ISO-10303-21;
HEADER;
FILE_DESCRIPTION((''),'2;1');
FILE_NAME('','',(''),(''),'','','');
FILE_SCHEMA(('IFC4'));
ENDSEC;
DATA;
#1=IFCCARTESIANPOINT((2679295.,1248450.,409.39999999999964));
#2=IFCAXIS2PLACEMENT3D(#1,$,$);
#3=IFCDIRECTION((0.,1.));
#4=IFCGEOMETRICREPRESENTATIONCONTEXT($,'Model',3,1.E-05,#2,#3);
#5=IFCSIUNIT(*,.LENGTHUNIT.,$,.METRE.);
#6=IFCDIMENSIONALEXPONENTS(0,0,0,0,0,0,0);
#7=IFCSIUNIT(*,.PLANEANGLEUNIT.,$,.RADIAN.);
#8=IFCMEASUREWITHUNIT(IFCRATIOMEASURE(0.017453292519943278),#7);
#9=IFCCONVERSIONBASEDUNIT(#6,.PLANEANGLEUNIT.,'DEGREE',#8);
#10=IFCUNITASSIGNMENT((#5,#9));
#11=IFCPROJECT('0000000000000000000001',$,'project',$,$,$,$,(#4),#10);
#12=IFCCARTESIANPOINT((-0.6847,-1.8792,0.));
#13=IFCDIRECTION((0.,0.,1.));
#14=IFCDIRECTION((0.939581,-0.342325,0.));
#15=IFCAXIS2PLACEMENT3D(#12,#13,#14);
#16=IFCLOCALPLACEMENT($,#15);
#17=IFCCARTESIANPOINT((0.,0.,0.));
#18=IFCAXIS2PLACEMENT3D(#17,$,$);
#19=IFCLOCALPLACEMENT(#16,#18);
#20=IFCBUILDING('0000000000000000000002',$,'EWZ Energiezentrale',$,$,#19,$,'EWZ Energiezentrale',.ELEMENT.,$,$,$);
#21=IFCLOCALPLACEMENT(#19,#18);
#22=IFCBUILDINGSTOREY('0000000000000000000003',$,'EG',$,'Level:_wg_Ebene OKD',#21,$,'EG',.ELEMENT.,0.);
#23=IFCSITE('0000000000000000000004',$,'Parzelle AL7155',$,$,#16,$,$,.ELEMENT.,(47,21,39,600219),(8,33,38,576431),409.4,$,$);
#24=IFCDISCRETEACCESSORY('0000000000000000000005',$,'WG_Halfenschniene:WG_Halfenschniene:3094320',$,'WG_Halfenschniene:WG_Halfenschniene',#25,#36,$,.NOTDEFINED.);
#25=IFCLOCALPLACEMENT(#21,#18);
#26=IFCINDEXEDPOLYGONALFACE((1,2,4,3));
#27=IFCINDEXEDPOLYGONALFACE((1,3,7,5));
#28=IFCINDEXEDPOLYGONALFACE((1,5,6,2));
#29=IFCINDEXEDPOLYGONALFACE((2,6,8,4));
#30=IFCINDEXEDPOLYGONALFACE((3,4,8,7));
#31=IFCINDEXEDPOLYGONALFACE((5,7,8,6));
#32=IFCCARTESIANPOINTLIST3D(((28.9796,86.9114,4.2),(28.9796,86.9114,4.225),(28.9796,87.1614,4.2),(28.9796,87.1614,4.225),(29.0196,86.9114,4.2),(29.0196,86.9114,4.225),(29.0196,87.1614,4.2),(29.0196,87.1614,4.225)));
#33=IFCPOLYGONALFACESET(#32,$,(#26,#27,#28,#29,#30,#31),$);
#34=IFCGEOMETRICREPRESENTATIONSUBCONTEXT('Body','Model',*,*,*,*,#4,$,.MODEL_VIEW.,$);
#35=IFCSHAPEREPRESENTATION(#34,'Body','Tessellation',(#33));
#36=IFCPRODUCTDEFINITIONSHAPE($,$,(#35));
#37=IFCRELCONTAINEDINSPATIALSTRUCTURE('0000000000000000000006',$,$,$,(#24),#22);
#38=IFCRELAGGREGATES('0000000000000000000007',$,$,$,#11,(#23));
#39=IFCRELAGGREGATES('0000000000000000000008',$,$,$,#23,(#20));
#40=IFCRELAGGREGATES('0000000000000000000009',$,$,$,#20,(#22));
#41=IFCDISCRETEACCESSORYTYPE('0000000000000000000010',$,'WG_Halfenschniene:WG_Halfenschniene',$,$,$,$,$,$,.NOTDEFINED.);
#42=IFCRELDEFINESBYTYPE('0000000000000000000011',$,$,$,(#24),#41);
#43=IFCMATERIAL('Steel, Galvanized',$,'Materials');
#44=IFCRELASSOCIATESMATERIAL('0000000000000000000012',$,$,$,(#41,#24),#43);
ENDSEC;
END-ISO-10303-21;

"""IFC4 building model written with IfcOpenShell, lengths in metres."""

from ifc_helpers import new_model, entity, si_unit, converted_unit, direction, frame, origin, place, context, subcontext, project, spatial, indexed_curve, outline, extrude, source, transform, mapped, material, type_object, element, save


model = new_model("IFC4")

# Units and contexts
model_context = context("Model", 3, precision=1e-05, world=frame((2679295.0, 1248450.0, 409.39999999999964)), true_north=direction((0.0, 1.0)))
body_context = subcontext(model_context, "Body", "Model", "MODEL_VIEW")
ifc_project = project(units=[si_unit("LENGTHUNIT", "METRE"), converted_unit("PLANEANGLEUNIT", "DEGREE", entity("IfcRatioMeasure", 0.017453292519943278), si_unit("PLANEANGLEUNIT", "RADIAN"), dimensions=[0, 0, 0, 0, 0, 0, 0])], contexts=[model_context])

# Site, building, storey
site_placement = place(None, frame((-0.6847, -1.8792, 0.0), z_axis=(0.0, 0.0, 1.0), x_axis=(0.939581, -0.342325, 0.0)))
site = spatial("IfcSite", under=ifc_project, at=site_placement, Name="Parzelle AL7155", CompositionType="ELEMENT", RefLatitude=(47, 21, 39, 600219), RefLongitude=(8, 33, 38, 576431), RefElevation=409.4)
building_placement = place(site_placement, origin())
building = spatial("IfcBuilding", under=site, at=building_placement, Name="EWZ Energiezentrale", LongName="EWZ Energiezentrale", CompositionType="ELEMENT")
storey_placement = place(building_placement, origin())
storey = spatial("IfcBuildingStorey", under=building, at=storey_placement, Name="EG", ObjectType="Level:_wg_Ebene OKD", LongName="EG", CompositionType="ELEMENT", Elevation=0.0)

# Discrete accessory
ifc_material = material(Name="Steel, Galvanized", Category="Materials")
discrete_accessory_type = type_object("IfcDiscreteAccessoryType", Name="WG_Halfenschniene:WG_Halfenschniene", PredefinedType="NOTDEFINED", material=ifc_material)
shared_shape = source(origin(), body_context, "Body", "SweptSolid", [
    extrude(outline(indexed_curve([(-0.125, -0.02), (0.125, -0.02), (0.125, 0.02), (-0.125, 0.02), (-0.125, -0.02)], self_intersect=False)), frame((0.125, 0.0, -0.0125)), (0.0, 0.0, 1.0), 0.025),
])
for number, where, z_axis, x_axis, name in (
    (1, (28.9996, 86.9114, 4.2125), (0.0, 0.0, -1.0), (0.0, 1.0, 0.0), "WG_Halfenschniene:WG_Halfenschniene:3094320"),
):
    element("IfcDiscreteAccessory", number, at=place(storey_placement, frame(where, z_axis=z_axis, x_axis=x_axis)), inside=storey, type_object=discrete_accessory_type, material=ifc_material, Name=name, ObjectType="WG_Halfenschniene:WG_Halfenschniene", PredefinedType="NOTDEFINED", context=body_context, shape_type="MappedRepresentation", body=[
        mapped(shared_shape, transform((0.0, 0.0, 0.0), scale=1.0)),
    ])

save(model, "model.ifc")
